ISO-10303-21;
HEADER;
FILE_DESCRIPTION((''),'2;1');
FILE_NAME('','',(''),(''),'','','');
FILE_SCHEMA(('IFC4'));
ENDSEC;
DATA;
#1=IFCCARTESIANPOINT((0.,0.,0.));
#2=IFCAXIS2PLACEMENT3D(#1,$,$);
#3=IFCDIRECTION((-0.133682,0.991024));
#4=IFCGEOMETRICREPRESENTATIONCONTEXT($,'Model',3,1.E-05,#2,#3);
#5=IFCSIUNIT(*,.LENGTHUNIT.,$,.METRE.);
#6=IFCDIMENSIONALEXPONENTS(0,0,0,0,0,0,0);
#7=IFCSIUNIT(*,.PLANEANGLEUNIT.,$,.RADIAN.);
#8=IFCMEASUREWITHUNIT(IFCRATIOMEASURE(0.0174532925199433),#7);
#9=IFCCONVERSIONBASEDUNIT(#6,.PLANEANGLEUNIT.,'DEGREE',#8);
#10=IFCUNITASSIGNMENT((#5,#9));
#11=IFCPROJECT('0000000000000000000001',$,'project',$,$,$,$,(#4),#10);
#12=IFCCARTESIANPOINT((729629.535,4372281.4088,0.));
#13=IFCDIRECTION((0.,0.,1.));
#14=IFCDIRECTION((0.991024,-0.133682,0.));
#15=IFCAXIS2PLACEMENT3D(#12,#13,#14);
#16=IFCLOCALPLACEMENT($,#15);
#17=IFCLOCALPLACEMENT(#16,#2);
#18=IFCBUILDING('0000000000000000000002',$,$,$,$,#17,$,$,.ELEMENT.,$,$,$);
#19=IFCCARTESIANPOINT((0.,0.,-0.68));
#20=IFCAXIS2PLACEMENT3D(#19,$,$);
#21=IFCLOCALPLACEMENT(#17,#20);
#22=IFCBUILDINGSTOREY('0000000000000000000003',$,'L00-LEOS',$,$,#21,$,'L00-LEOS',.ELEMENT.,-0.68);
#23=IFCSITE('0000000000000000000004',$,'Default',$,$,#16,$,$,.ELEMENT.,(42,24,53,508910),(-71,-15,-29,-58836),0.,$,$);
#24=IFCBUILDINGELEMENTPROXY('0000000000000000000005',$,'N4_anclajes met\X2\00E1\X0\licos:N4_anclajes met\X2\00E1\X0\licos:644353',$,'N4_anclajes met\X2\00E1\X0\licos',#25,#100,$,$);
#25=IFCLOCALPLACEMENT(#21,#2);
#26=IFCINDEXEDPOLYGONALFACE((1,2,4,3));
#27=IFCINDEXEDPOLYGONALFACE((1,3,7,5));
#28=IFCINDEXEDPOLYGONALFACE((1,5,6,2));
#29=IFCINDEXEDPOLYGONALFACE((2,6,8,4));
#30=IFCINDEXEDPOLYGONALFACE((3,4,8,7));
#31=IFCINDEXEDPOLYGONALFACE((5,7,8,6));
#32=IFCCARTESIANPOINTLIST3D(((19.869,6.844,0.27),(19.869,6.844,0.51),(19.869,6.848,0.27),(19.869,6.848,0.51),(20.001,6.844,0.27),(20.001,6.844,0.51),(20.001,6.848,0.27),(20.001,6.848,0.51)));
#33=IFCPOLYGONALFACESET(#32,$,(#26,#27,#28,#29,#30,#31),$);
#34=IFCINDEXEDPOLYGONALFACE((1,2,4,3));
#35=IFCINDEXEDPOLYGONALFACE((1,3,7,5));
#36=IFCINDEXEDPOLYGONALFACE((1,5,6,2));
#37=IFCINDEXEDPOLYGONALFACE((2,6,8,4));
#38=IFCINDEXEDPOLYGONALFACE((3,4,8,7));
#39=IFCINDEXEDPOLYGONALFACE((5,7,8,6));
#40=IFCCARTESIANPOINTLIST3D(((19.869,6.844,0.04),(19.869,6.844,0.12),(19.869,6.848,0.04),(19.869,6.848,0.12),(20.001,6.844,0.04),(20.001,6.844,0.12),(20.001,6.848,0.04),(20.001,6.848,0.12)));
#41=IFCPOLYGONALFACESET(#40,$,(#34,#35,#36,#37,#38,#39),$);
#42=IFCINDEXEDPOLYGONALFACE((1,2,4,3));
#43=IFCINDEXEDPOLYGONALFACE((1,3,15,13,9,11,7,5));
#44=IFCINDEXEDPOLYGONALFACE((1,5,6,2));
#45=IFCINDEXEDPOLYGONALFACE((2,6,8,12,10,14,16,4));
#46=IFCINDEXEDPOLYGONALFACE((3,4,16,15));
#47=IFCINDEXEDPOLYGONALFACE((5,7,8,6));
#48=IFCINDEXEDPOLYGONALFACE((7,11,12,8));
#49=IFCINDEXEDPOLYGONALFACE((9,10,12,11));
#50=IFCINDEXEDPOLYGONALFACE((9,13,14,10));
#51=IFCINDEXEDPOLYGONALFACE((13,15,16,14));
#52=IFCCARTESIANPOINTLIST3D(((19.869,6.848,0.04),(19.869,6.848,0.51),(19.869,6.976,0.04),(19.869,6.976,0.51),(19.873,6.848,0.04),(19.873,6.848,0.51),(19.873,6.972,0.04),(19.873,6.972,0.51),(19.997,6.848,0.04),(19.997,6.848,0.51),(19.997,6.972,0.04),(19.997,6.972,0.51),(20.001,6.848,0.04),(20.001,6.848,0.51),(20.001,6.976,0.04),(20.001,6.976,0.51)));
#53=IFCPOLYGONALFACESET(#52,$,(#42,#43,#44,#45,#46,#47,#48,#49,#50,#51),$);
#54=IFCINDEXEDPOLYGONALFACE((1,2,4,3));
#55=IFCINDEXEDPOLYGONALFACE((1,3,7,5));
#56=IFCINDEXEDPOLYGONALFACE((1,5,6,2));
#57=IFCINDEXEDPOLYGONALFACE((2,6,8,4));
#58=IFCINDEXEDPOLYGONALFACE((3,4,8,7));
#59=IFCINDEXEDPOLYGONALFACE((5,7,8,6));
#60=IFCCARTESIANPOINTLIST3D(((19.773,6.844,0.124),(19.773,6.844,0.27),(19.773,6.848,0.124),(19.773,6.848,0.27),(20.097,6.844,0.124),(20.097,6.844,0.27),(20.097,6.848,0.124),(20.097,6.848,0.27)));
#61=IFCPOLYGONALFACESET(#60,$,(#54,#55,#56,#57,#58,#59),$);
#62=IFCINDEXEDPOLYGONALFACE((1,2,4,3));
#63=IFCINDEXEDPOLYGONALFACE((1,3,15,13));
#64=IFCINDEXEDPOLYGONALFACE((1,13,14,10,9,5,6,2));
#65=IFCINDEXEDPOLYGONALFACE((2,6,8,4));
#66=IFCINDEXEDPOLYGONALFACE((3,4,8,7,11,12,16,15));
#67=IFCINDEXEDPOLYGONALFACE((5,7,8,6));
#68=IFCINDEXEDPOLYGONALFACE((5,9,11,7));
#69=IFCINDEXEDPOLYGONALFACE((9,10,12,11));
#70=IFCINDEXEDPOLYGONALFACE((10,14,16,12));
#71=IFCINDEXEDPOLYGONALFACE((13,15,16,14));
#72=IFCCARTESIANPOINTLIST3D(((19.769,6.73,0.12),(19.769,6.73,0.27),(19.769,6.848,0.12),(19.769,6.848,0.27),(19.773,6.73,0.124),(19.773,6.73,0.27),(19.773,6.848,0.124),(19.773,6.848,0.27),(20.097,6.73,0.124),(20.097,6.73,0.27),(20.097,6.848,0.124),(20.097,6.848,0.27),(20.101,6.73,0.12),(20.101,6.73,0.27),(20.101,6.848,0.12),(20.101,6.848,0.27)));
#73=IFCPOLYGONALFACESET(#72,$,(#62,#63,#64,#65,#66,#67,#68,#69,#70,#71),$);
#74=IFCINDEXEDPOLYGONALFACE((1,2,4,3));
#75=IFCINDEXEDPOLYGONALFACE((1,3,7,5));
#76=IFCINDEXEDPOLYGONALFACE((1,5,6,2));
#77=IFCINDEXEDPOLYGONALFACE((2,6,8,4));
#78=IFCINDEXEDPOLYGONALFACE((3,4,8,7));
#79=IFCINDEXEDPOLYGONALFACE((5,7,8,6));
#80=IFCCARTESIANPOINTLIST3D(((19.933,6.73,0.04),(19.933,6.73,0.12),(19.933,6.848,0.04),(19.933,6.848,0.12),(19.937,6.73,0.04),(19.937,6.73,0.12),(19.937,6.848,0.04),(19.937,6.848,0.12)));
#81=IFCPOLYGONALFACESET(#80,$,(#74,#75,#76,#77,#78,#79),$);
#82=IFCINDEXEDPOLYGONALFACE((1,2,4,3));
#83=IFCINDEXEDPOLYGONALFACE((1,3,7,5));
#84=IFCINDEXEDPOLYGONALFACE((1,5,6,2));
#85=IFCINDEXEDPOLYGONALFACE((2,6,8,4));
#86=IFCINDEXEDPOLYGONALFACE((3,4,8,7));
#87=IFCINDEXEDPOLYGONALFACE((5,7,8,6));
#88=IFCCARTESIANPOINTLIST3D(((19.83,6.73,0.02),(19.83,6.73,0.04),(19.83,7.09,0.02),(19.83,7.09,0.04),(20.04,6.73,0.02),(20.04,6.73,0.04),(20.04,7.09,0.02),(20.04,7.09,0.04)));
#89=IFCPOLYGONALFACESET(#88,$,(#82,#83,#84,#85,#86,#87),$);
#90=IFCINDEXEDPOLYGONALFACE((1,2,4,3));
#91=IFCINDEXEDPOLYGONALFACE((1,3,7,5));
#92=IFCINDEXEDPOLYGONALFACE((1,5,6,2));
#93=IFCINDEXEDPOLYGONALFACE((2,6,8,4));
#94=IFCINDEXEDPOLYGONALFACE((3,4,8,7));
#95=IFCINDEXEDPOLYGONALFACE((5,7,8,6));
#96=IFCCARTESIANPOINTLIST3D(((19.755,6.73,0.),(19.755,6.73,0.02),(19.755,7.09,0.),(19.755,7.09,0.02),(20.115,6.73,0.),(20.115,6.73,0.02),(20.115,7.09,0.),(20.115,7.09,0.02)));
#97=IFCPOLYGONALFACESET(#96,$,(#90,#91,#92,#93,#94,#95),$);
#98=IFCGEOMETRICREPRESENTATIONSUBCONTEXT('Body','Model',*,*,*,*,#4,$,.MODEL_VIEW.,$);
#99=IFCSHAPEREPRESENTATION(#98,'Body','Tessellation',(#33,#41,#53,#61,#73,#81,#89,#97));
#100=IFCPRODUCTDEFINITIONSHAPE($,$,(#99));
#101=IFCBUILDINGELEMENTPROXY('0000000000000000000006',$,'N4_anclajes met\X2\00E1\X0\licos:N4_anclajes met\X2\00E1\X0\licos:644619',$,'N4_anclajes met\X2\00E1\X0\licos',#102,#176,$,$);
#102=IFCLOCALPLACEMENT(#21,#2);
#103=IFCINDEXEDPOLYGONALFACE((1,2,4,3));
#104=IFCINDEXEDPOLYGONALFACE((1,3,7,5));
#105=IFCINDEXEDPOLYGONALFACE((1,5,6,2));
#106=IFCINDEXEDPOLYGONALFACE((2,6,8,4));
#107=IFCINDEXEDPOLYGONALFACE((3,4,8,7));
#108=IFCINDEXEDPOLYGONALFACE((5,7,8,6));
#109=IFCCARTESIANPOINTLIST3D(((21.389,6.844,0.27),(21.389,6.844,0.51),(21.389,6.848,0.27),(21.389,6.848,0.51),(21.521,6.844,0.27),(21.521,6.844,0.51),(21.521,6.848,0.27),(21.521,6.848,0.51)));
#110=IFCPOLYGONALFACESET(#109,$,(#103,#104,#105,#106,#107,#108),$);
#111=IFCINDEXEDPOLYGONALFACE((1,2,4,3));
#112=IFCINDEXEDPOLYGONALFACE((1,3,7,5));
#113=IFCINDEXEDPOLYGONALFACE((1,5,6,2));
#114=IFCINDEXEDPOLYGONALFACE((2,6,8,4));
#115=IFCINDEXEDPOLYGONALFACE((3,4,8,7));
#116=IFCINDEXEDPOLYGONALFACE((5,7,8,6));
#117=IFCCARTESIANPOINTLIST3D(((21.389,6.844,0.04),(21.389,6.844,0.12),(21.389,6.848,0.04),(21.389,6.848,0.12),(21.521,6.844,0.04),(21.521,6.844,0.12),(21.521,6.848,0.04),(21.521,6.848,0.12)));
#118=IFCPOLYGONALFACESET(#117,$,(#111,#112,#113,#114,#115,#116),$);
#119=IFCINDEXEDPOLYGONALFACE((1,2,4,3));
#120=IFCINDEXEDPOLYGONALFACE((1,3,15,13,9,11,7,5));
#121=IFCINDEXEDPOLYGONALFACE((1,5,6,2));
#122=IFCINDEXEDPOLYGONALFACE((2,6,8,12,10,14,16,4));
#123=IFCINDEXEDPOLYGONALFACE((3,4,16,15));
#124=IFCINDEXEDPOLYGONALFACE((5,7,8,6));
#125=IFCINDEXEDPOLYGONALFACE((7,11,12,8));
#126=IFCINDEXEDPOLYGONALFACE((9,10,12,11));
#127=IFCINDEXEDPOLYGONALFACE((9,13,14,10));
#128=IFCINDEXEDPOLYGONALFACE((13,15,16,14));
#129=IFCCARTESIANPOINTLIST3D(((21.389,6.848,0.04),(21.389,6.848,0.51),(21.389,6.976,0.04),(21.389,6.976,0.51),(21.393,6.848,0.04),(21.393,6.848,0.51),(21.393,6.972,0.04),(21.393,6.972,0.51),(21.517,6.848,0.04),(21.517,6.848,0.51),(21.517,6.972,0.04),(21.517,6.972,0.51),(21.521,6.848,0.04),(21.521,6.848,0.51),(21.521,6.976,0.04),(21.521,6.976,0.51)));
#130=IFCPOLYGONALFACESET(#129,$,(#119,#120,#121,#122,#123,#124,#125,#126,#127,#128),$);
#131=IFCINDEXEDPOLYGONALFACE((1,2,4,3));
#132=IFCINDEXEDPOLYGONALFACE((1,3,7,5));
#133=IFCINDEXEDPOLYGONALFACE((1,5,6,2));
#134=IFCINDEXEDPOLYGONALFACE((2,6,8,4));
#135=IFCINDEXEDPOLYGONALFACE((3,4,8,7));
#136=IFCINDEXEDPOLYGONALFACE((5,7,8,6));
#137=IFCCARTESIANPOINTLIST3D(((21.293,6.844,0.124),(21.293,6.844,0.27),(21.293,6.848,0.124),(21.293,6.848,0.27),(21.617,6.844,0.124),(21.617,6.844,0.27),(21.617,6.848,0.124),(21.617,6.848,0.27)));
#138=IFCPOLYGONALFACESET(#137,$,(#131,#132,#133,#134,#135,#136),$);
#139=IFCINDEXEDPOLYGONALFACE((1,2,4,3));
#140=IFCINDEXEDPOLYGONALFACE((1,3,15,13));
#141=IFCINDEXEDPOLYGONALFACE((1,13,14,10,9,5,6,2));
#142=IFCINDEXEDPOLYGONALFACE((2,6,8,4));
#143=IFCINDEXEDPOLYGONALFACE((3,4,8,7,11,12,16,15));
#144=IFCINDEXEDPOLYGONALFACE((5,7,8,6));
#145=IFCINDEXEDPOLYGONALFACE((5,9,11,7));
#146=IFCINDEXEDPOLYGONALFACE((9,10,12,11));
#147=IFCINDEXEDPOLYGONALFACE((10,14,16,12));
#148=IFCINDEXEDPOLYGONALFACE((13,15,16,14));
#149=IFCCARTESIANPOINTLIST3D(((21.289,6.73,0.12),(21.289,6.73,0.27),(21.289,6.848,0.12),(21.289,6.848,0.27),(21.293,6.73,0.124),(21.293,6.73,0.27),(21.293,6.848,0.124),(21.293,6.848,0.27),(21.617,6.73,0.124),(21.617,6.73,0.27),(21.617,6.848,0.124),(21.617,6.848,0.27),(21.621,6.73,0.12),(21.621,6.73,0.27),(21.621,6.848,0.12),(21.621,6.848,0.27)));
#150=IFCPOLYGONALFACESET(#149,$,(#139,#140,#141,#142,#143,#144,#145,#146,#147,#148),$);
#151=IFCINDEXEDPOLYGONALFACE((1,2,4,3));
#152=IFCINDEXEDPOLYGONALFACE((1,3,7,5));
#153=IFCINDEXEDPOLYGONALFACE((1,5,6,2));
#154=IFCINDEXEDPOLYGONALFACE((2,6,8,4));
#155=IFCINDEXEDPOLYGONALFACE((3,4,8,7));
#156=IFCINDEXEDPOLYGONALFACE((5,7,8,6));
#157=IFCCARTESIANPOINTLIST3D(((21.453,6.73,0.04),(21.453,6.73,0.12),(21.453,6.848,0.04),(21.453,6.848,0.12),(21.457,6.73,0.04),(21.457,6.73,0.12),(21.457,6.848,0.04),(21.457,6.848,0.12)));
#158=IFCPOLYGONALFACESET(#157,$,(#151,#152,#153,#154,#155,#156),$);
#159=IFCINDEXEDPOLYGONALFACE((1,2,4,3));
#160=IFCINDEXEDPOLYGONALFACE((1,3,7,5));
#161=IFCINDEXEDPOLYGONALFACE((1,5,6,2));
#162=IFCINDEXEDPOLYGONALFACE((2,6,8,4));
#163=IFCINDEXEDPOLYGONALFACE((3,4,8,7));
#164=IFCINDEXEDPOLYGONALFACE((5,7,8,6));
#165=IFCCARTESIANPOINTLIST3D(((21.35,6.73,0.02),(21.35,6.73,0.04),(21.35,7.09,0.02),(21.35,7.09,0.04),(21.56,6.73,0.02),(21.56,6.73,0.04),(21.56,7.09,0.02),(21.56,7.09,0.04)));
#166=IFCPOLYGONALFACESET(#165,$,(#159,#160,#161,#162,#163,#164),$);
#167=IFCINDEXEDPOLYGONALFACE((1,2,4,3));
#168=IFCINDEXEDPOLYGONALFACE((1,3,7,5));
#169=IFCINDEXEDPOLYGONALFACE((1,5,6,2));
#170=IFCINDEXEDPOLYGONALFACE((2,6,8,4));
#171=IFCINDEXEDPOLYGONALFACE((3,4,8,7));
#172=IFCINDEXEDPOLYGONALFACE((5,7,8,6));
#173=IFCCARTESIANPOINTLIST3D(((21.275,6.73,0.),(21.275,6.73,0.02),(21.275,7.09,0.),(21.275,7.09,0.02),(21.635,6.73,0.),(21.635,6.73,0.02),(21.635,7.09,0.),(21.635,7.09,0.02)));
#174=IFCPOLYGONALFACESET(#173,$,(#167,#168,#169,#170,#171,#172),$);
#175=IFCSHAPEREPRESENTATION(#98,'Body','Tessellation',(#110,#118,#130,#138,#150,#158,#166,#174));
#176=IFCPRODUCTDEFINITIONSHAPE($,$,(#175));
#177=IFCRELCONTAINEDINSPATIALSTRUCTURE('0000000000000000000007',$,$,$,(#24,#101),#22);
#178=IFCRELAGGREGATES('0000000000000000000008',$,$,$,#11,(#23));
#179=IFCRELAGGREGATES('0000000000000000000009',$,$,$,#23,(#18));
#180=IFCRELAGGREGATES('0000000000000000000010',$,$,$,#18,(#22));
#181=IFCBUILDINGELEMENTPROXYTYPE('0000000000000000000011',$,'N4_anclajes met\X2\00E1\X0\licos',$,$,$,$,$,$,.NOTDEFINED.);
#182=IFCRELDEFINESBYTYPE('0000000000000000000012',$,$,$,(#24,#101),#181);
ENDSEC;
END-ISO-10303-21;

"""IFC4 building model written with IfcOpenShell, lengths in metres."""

from ifc_helpers import new_model, entity, si_unit, converted_unit, direction, frame, frame_2d, origin, origin_2d_with_axis, place, context, subcontext, project, spatial, polyline, rectangle, outline, extrude, source, transform, mapped, type_object, type_shapes, element, save


model = new_model("IFC4")

# Units and contexts
model_context = context("Model", 3, precision=1e-05, world=origin(), true_north=direction((-0.133682, 0.991024)))
body_context = subcontext(model_context, "Body", "Model", "MODEL_VIEW")
ifc_project = project(units=[si_unit("LENGTHUNIT", "METRE"), converted_unit("PLANEANGLEUNIT", "DEGREE", entity("IfcRatioMeasure", 0.0174532925199433), si_unit("PLANEANGLEUNIT", "RADIAN"), dimensions=[0, 0, 0, 0, 0, 0, 0])], contexts=[model_context])

# Site, building, storey
site_placement = place(None, frame((729629.535, 4372281.4088, 0.0), z_axis=(0.0, 0.0, 1.0), x_axis=(0.991024, -0.133682, 0.0)))
site = spatial("IfcSite", under=ifc_project, at=site_placement, Name="Default", CompositionType="ELEMENT", RefLatitude=(42, 24, 53, 508910), RefLongitude=(-71, -15, -29, -58836), RefElevation=0.0)
building_placement = place(site_placement, origin())
building = spatial("IfcBuilding", under=site, at=building_placement, CompositionType="ELEMENT")
storey_placement = place(building_placement, frame((0.0, 0.0, -0.68)))
storey = spatial("IfcBuildingStorey", under=building, at=storey_placement, Name="L00-LEOS", LongName="L00-LEOS", CompositionType="ELEMENT", Elevation=-0.68)

# Building element proxies
building_element_proxy_type_1 = type_object("IfcBuildingElementProxyType", Name="N4_anclajes metálicos")
shared_shape_1 = source(origin(), body_context, "Body", "SweptSolid", [
    extrude(rectangle(XDim=0.132, YDim=0.004, at=frame_2d((0.0, 0.0), x_axis=(1.0, 0.0))), frame((-0.064, 0.0, 0.27), z_axis=(0.0, 0.0, 1.0), x_axis=(0.0, 1.0, 0.0)), (0.0, 0.0, 1.0), 0.24),
    extrude(rectangle(XDim=0.132, YDim=0.004, at=frame_2d((0.0, 0.0), x_axis=(1.0, 0.0))), frame((-0.064, 0.0, 0.04), z_axis=(0.0, 0.0, 1.0), x_axis=(0.0, 1.0, 0.0)), (0.0, 0.0, 1.0), 0.08),
    extrude(outline(polyline([(-0.065, -0.066), (0.063, -0.066), (0.063, -0.062), (-0.061, -0.062), (-0.061, 0.062), (0.063, 0.062), (0.063, 0.066), (-0.065, 0.066), (-0.065, -0.066)])), frame((0.001, 0.0, 0.04), z_axis=(0.0, 0.0, 1.0), x_axis=(-1.0, 0.0, 0.0)), (0.0, 0.0, 1.0), 0.47),
    extrude(rectangle(XDim=0.324, YDim=0.004, at=frame_2d((0.0, 0.0), x_axis=(1.0, 0.0))), frame((-0.064, 0.0, 0.124), z_axis=(0.0, 0.0, 1.0), x_axis=(0.0, -1.0, 0.0)), (0.0, 0.0, 1.0), 0.146),
    extrude(outline(polyline([(-0.076, -0.166), (0.074, -0.166), (0.074, -0.162), (-0.072, -0.162), (-0.072, 0.162), (0.074, 0.162), (0.074, 0.166), (-0.076, 0.166), (-0.076, -0.166)])), frame((-0.18, 0.0, 0.196), z_axis=(1.0, 0.0, 0.0), x_axis=(0.0, 0.0, 1.0)), (0.0, 0.0, 1.0), 0.118),
    extrude(rectangle(XDim=0.004, YDim=0.118, at=origin_2d_with_axis()), frame((-0.121, 0.0, 0.04), z_axis=(0.0, 0.0, 1.0), x_axis=(0.0, -1.0, 0.0)), (0.0, 0.0, 1.0), 0.08),
    extrude(rectangle(XDim=0.36, YDim=0.21, at=frame_2d((0.0, 0.0), x_axis=(1.0, 0.0))), frame((0.0, 0.0, 0.02), z_axis=(0.0, 0.0, 1.0), x_axis=(-1.0, 0.0, 0.0)), (0.0, 0.0, 1.0), 0.02),
    extrude(rectangle(XDim=0.36, YDim=0.36, at=frame_2d((0.0, 0.0), x_axis=(1.0, 0.0))), frame((0.0, 0.0, 0.0), z_axis=(0.0, 0.0, 1.0), x_axis=(-1.0, 0.0, 0.0)), (0.0, 0.0, 1.0), 0.02),
])
type_shapes(building_element_proxy_type_1, [shared_shape_1])
for number, where, z_axis, x_axis, name in (
    (1, (19.935, 6.91, 0.0), (0.0, 0.0, 1.0), (0.0, 1.0, 0.0), "N4_anclajes metálicos:N4_anclajes metálicos:644353"),
    (2, (21.455, 6.91, 0.0), (0.0, 0.0, 1.0), (0.0, 1.0, 0.0), "N4_anclajes metálicos:N4_anclajes metálicos:644619"),
):
    element("IfcBuildingElementProxy", number, at=place(storey_placement, frame(where, z_axis=z_axis, x_axis=x_axis)), inside=storey, type_object=building_element_proxy_type_1, Name=name, ObjectType="N4_anclajes metálicos", context=body_context, shape_type="MappedRepresentation", body=[
        mapped(shared_shape_1, transform((0.0, 0.0, 0.0), scale=1.0)),
    ])

save(model, "model.ifc")
